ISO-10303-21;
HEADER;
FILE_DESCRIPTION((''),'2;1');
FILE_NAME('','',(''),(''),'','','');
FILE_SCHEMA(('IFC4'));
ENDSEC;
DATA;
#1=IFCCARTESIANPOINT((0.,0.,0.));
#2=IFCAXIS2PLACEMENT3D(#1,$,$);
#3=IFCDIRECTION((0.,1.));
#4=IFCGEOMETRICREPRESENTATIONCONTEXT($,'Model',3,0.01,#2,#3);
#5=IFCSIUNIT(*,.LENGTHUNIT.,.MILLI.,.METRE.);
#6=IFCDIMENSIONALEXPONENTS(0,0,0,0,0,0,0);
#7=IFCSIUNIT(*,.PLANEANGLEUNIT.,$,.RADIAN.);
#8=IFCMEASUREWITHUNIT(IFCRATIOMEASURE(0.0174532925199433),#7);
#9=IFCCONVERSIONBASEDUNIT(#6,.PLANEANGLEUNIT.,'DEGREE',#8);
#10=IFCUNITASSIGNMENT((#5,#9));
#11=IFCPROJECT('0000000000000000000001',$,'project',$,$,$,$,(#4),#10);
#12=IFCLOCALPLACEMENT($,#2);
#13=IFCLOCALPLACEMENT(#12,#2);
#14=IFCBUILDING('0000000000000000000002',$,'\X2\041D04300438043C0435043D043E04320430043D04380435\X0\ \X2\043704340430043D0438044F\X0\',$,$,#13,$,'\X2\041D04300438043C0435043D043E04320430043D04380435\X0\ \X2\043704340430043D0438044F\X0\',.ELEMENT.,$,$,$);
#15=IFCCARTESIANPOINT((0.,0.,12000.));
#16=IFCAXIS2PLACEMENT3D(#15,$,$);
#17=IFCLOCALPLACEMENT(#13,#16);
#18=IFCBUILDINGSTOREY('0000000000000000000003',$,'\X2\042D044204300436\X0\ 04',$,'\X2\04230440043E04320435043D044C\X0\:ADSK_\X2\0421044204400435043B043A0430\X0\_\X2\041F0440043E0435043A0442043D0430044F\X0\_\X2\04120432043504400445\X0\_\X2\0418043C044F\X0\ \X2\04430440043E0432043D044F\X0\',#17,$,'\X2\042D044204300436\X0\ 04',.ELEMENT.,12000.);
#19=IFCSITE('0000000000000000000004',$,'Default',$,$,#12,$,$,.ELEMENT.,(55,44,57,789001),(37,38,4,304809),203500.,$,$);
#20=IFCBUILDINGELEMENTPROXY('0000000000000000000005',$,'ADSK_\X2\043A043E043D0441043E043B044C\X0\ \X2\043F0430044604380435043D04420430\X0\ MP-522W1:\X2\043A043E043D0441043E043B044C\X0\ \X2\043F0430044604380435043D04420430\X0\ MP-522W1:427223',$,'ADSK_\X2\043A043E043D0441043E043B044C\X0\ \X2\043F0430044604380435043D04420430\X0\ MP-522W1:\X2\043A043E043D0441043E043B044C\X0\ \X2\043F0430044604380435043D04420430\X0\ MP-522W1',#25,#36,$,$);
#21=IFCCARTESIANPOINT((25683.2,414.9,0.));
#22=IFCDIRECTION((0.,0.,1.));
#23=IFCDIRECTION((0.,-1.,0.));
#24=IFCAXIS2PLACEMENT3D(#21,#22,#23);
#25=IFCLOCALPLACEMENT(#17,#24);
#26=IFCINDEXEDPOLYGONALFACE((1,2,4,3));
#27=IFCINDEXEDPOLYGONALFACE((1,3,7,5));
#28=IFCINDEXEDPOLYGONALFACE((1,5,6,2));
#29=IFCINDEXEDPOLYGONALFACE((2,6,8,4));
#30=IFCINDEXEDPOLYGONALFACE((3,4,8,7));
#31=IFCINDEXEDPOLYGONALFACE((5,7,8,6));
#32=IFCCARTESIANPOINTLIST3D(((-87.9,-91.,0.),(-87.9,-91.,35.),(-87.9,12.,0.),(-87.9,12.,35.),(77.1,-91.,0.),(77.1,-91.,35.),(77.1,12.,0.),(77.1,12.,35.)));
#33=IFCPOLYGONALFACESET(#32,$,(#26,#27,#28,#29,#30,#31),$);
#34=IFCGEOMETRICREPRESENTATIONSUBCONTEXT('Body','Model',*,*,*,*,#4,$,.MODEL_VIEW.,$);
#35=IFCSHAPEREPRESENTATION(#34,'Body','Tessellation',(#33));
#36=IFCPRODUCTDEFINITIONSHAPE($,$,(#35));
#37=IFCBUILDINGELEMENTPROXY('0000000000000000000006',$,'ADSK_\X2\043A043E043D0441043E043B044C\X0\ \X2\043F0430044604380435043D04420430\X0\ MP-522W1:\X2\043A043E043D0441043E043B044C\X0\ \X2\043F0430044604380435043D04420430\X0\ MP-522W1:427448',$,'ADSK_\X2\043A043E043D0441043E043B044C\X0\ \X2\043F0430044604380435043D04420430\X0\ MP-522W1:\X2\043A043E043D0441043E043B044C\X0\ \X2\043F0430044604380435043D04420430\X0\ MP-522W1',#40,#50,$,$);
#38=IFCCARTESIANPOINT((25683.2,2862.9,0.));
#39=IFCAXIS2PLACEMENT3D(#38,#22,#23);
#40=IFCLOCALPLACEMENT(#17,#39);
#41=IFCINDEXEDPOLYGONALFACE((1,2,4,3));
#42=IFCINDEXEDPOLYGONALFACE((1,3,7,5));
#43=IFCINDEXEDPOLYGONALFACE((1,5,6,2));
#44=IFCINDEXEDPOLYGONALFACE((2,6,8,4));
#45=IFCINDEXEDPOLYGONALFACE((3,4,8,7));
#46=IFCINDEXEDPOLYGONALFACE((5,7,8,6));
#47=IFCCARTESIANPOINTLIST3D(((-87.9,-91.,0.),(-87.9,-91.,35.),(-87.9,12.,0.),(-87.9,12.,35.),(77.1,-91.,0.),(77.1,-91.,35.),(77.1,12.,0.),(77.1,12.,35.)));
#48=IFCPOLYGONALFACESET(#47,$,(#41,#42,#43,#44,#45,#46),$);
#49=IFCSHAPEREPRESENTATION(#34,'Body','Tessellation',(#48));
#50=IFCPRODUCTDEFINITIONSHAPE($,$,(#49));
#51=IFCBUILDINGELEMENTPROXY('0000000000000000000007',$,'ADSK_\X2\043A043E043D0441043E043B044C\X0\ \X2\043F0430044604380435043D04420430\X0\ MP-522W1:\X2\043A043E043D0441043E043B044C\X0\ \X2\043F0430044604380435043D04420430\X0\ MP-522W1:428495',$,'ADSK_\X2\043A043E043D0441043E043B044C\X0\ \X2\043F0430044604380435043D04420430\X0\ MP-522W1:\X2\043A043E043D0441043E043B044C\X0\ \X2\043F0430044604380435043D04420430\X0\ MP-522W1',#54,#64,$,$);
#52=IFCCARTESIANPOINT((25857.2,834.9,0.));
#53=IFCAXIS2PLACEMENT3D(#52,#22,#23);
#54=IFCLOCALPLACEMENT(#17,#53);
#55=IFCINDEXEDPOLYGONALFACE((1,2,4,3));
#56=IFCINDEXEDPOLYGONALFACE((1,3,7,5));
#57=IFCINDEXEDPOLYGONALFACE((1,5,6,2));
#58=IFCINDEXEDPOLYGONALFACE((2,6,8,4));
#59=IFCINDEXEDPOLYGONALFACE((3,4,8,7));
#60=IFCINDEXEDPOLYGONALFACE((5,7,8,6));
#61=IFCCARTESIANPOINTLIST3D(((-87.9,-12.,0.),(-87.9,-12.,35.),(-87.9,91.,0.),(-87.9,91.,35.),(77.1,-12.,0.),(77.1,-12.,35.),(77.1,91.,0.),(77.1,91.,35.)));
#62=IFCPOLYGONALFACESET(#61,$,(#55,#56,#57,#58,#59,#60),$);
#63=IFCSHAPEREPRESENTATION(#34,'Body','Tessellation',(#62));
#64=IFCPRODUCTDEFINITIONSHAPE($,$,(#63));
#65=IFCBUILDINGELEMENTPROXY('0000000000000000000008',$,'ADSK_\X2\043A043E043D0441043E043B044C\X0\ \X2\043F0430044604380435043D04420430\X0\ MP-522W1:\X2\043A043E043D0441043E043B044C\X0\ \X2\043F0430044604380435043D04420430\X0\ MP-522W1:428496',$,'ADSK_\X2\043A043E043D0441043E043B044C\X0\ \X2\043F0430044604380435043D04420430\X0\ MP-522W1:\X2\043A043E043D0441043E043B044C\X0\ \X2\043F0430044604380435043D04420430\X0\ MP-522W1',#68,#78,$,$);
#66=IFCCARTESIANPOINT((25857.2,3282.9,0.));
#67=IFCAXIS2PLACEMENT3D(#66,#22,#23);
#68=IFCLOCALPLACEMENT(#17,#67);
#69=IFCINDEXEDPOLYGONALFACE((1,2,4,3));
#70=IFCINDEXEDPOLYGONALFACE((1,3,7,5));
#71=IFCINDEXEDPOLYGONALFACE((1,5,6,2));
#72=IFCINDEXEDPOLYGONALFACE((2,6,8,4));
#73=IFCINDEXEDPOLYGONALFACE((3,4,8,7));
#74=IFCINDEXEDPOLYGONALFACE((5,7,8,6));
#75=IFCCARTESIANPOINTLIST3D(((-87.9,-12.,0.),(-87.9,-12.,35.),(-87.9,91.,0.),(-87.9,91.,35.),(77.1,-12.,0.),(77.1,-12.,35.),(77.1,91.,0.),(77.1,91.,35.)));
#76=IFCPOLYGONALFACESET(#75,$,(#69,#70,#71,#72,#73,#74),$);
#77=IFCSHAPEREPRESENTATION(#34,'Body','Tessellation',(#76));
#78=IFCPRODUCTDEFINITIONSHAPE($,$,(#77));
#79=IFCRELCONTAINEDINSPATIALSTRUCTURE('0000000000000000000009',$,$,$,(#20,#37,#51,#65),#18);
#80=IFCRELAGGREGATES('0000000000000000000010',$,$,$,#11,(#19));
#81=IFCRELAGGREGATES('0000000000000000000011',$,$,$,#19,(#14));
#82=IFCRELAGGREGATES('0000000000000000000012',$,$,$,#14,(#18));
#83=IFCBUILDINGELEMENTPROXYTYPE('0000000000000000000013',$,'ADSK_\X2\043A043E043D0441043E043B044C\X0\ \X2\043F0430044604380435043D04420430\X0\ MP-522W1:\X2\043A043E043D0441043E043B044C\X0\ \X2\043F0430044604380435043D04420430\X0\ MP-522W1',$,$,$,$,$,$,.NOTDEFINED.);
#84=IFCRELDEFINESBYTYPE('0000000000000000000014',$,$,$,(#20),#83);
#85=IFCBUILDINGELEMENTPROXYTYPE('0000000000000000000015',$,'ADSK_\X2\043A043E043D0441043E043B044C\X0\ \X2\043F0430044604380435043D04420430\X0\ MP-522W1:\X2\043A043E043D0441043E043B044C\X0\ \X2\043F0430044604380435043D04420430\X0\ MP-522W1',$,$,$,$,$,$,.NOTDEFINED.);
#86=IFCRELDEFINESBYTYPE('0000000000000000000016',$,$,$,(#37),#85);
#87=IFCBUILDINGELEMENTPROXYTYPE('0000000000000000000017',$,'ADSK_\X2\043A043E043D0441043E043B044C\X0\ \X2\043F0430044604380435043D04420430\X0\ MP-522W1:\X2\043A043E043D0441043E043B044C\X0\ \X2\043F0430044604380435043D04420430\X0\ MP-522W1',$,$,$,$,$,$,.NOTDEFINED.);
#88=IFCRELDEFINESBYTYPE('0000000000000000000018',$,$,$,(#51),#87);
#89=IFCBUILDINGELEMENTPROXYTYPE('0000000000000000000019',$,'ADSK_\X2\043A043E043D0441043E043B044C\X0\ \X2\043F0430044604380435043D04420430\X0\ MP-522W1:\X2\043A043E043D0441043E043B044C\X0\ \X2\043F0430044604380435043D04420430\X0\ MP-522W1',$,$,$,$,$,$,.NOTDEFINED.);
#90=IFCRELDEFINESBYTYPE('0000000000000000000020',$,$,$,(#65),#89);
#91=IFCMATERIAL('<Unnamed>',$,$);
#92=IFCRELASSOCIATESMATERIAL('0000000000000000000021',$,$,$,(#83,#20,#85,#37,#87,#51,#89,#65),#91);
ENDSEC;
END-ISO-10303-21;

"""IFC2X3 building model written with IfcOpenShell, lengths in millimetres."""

from ifc_helpers import new_model, entity, si_unit, converted_unit, direction, frame, origin, origin_2d_with_axis, place, context, subcontext, project, spatial, rectangle, extrude, source, transform, mapped, material, type_object, type_shapes, element, save


model = new_model("IFC2X3")

# Units and contexts
model_context = context("Model", 3, precision=0.01, world=origin(), true_north=direction((0.0, 1.0)))
body_context = subcontext(model_context, "Body", "Model", "MODEL_VIEW")
ifc_project = project(units=[si_unit("LENGTHUNIT", "METRE", prefix="MILLI"), converted_unit("PLANEANGLEUNIT", "DEGREE", entity("IfcRatioMeasure", 0.0174532925199433), si_unit("PLANEANGLEUNIT", "RADIAN"), dimensions=[0, 0, 0, 0, 0, 0, 0])], contexts=[model_context])

# Site, building, storey
site_placement = place(None, origin())
site = spatial("IfcSite", under=ifc_project, at=site_placement, Name="Default", CompositionType="ELEMENT", RefLatitude=(55, 44, 57, 789001), RefLongitude=(37, 38, 4, 304809), RefElevation=203500.0)
building_placement = place(site_placement, origin())
building = spatial("IfcBuilding", under=site, at=building_placement, Name="Наименование здания", LongName="Наименование здания", CompositionType="ELEMENT")
storey_placement = place(building_placement, frame((0.0, 0.0, 12000.0)))
storey = spatial("IfcBuildingStorey", under=building, at=storey_placement, Name="Этаж 04", ObjectType="Уровень:ADSK_Стрелка_Проектная_Вверх_Имя уровня", LongName="Этаж 04", CompositionType="ELEMENT", Elevation=12000.0)

# Building element proxies
ifc_material_1 = material(Name="<Unnamed>")
building_element_proxy_type_1 = type_object("IfcBuildingElementProxyType", Name="ADSK_консоль пациента MP-522W1:консоль пациента MP-522W1", PredefinedType="NOTDEFINED", material=ifc_material_1)
shared_shape_1 = source(origin(), body_context, "Body", "SweptSolid", [
    extrude(rectangle(XDim=165.0, YDim=103.0, at=origin_2d_with_axis()), frame((-5.4, -39.5, 0.0), z_axis=(0.0, 0.0, 1.0), x_axis=(-1.0, 0.0, 0.0)), (0.0, 0.0, 1.0), 35.0),
])
type_shapes(building_element_proxy_type_1, [shared_shape_1])
proxy_1_placement = place(storey_placement, frame((25683.2, 414.9, 0.0), z_axis=(0.0, 0.0, 1.0), x_axis=(0.0, -1.0, 0.0)))
element("IfcBuildingElementProxy", 1, at=proxy_1_placement, inside=storey, type_object=building_element_proxy_type_1, material=ifc_material_1, Name="ADSK_консоль пациента MP-522W1:консоль пациента MP-522W1:427223", ObjectType="ADSK_консоль пациента MP-522W1:консоль пациента MP-522W1", context=body_context, shape_type="MappedRepresentation", body=[
    mapped(shared_shape_1, transform((0.0, 0.0, 0.0), scale=1.0)),
])
building_element_proxy_type_2 = type_object("IfcBuildingElementProxyType", Name="ADSK_консоль пациента MP-522W1:консоль пациента MP-522W1", PredefinedType="NOTDEFINED", material=ifc_material_1)
type_shapes(building_element_proxy_type_2, [shared_shape_1])
proxy_2_placement = place(storey_placement, frame((25683.2, 2862.9, 0.0), z_axis=(0.0, 0.0, 1.0), x_axis=(0.0, -1.0, 0.0)))
element("IfcBuildingElementProxy", 2, at=proxy_2_placement, inside=storey, type_object=building_element_proxy_type_2, material=ifc_material_1, Name="ADSK_консоль пациента MP-522W1:консоль пациента MP-522W1:427448", ObjectType="ADSK_консоль пациента MP-522W1:консоль пациента MP-522W1", context=body_context, shape_type="MappedRepresentation", body=[
    mapped(shared_shape_1, transform((0.0, 0.0, 0.0), scale=1.0)),
])
building_element_proxy_type_3 = type_object("IfcBuildingElementProxyType", Name="ADSK_консоль пациента MP-522W1:консоль пациента MP-522W1", PredefinedType="NOTDEFINED", material=ifc_material_1)
shared_shape_2 = source(origin(), body_context, "Body", "SweptSolid", [
    extrude(rectangle(XDim=103.0, YDim=165.0, at=origin_2d_with_axis()), frame((-5.4, 39.5, 0.0), z_axis=(0.0, 0.0, 1.0), x_axis=(0.0, 1.0, 0.0)), (0.0, 0.0, 1.0), 35.0),
])
type_shapes(building_element_proxy_type_3, [shared_shape_2])
proxy_3_placement = place(storey_placement, frame((25857.2, 834.9, 0.0), z_axis=(0.0, 0.0, 1.0), x_axis=(0.0, -1.0, 0.0)))
element("IfcBuildingElementProxy", 3, at=proxy_3_placement, inside=storey, type_object=building_element_proxy_type_3, material=ifc_material_1, Name="ADSK_консоль пациента MP-522W1:консоль пациента MP-522W1:428495", ObjectType="ADSK_консоль пациента MP-522W1:консоль пациента MP-522W1", context=body_context, shape_type="MappedRepresentation", body=[
    mapped(shared_shape_2, transform((0.0, 0.0, 0.0), scale=1.0)),
])
building_element_proxy_type_4 = type_object("IfcBuildingElementProxyType", Name="ADSK_консоль пациента MP-522W1:консоль пациента MP-522W1", PredefinedType="NOTDEFINED", material=ifc_material_1)
type_shapes(building_element_proxy_type_4, [shared_shape_2])
proxy_4_placement = place(storey_placement, frame((25857.2, 3282.9, 0.0), z_axis=(0.0, 0.0, 1.0), x_axis=(0.0, -1.0, 0.0)))
element("IfcBuildingElementProxy", 4, at=proxy_4_placement, inside=storey, type_object=building_element_proxy_type_4, material=ifc_material_1, Name="ADSK_консоль пациента MP-522W1:консоль пациента MP-522W1:428496", ObjectType="ADSK_консоль пациента MP-522W1:консоль пациента MP-522W1", context=body_context, shape_type="MappedRepresentation", body=[
    mapped(shared_shape_2, transform((0.0, 0.0, 0.0), scale=1.0)),
])

save(model, "model.ifc")
